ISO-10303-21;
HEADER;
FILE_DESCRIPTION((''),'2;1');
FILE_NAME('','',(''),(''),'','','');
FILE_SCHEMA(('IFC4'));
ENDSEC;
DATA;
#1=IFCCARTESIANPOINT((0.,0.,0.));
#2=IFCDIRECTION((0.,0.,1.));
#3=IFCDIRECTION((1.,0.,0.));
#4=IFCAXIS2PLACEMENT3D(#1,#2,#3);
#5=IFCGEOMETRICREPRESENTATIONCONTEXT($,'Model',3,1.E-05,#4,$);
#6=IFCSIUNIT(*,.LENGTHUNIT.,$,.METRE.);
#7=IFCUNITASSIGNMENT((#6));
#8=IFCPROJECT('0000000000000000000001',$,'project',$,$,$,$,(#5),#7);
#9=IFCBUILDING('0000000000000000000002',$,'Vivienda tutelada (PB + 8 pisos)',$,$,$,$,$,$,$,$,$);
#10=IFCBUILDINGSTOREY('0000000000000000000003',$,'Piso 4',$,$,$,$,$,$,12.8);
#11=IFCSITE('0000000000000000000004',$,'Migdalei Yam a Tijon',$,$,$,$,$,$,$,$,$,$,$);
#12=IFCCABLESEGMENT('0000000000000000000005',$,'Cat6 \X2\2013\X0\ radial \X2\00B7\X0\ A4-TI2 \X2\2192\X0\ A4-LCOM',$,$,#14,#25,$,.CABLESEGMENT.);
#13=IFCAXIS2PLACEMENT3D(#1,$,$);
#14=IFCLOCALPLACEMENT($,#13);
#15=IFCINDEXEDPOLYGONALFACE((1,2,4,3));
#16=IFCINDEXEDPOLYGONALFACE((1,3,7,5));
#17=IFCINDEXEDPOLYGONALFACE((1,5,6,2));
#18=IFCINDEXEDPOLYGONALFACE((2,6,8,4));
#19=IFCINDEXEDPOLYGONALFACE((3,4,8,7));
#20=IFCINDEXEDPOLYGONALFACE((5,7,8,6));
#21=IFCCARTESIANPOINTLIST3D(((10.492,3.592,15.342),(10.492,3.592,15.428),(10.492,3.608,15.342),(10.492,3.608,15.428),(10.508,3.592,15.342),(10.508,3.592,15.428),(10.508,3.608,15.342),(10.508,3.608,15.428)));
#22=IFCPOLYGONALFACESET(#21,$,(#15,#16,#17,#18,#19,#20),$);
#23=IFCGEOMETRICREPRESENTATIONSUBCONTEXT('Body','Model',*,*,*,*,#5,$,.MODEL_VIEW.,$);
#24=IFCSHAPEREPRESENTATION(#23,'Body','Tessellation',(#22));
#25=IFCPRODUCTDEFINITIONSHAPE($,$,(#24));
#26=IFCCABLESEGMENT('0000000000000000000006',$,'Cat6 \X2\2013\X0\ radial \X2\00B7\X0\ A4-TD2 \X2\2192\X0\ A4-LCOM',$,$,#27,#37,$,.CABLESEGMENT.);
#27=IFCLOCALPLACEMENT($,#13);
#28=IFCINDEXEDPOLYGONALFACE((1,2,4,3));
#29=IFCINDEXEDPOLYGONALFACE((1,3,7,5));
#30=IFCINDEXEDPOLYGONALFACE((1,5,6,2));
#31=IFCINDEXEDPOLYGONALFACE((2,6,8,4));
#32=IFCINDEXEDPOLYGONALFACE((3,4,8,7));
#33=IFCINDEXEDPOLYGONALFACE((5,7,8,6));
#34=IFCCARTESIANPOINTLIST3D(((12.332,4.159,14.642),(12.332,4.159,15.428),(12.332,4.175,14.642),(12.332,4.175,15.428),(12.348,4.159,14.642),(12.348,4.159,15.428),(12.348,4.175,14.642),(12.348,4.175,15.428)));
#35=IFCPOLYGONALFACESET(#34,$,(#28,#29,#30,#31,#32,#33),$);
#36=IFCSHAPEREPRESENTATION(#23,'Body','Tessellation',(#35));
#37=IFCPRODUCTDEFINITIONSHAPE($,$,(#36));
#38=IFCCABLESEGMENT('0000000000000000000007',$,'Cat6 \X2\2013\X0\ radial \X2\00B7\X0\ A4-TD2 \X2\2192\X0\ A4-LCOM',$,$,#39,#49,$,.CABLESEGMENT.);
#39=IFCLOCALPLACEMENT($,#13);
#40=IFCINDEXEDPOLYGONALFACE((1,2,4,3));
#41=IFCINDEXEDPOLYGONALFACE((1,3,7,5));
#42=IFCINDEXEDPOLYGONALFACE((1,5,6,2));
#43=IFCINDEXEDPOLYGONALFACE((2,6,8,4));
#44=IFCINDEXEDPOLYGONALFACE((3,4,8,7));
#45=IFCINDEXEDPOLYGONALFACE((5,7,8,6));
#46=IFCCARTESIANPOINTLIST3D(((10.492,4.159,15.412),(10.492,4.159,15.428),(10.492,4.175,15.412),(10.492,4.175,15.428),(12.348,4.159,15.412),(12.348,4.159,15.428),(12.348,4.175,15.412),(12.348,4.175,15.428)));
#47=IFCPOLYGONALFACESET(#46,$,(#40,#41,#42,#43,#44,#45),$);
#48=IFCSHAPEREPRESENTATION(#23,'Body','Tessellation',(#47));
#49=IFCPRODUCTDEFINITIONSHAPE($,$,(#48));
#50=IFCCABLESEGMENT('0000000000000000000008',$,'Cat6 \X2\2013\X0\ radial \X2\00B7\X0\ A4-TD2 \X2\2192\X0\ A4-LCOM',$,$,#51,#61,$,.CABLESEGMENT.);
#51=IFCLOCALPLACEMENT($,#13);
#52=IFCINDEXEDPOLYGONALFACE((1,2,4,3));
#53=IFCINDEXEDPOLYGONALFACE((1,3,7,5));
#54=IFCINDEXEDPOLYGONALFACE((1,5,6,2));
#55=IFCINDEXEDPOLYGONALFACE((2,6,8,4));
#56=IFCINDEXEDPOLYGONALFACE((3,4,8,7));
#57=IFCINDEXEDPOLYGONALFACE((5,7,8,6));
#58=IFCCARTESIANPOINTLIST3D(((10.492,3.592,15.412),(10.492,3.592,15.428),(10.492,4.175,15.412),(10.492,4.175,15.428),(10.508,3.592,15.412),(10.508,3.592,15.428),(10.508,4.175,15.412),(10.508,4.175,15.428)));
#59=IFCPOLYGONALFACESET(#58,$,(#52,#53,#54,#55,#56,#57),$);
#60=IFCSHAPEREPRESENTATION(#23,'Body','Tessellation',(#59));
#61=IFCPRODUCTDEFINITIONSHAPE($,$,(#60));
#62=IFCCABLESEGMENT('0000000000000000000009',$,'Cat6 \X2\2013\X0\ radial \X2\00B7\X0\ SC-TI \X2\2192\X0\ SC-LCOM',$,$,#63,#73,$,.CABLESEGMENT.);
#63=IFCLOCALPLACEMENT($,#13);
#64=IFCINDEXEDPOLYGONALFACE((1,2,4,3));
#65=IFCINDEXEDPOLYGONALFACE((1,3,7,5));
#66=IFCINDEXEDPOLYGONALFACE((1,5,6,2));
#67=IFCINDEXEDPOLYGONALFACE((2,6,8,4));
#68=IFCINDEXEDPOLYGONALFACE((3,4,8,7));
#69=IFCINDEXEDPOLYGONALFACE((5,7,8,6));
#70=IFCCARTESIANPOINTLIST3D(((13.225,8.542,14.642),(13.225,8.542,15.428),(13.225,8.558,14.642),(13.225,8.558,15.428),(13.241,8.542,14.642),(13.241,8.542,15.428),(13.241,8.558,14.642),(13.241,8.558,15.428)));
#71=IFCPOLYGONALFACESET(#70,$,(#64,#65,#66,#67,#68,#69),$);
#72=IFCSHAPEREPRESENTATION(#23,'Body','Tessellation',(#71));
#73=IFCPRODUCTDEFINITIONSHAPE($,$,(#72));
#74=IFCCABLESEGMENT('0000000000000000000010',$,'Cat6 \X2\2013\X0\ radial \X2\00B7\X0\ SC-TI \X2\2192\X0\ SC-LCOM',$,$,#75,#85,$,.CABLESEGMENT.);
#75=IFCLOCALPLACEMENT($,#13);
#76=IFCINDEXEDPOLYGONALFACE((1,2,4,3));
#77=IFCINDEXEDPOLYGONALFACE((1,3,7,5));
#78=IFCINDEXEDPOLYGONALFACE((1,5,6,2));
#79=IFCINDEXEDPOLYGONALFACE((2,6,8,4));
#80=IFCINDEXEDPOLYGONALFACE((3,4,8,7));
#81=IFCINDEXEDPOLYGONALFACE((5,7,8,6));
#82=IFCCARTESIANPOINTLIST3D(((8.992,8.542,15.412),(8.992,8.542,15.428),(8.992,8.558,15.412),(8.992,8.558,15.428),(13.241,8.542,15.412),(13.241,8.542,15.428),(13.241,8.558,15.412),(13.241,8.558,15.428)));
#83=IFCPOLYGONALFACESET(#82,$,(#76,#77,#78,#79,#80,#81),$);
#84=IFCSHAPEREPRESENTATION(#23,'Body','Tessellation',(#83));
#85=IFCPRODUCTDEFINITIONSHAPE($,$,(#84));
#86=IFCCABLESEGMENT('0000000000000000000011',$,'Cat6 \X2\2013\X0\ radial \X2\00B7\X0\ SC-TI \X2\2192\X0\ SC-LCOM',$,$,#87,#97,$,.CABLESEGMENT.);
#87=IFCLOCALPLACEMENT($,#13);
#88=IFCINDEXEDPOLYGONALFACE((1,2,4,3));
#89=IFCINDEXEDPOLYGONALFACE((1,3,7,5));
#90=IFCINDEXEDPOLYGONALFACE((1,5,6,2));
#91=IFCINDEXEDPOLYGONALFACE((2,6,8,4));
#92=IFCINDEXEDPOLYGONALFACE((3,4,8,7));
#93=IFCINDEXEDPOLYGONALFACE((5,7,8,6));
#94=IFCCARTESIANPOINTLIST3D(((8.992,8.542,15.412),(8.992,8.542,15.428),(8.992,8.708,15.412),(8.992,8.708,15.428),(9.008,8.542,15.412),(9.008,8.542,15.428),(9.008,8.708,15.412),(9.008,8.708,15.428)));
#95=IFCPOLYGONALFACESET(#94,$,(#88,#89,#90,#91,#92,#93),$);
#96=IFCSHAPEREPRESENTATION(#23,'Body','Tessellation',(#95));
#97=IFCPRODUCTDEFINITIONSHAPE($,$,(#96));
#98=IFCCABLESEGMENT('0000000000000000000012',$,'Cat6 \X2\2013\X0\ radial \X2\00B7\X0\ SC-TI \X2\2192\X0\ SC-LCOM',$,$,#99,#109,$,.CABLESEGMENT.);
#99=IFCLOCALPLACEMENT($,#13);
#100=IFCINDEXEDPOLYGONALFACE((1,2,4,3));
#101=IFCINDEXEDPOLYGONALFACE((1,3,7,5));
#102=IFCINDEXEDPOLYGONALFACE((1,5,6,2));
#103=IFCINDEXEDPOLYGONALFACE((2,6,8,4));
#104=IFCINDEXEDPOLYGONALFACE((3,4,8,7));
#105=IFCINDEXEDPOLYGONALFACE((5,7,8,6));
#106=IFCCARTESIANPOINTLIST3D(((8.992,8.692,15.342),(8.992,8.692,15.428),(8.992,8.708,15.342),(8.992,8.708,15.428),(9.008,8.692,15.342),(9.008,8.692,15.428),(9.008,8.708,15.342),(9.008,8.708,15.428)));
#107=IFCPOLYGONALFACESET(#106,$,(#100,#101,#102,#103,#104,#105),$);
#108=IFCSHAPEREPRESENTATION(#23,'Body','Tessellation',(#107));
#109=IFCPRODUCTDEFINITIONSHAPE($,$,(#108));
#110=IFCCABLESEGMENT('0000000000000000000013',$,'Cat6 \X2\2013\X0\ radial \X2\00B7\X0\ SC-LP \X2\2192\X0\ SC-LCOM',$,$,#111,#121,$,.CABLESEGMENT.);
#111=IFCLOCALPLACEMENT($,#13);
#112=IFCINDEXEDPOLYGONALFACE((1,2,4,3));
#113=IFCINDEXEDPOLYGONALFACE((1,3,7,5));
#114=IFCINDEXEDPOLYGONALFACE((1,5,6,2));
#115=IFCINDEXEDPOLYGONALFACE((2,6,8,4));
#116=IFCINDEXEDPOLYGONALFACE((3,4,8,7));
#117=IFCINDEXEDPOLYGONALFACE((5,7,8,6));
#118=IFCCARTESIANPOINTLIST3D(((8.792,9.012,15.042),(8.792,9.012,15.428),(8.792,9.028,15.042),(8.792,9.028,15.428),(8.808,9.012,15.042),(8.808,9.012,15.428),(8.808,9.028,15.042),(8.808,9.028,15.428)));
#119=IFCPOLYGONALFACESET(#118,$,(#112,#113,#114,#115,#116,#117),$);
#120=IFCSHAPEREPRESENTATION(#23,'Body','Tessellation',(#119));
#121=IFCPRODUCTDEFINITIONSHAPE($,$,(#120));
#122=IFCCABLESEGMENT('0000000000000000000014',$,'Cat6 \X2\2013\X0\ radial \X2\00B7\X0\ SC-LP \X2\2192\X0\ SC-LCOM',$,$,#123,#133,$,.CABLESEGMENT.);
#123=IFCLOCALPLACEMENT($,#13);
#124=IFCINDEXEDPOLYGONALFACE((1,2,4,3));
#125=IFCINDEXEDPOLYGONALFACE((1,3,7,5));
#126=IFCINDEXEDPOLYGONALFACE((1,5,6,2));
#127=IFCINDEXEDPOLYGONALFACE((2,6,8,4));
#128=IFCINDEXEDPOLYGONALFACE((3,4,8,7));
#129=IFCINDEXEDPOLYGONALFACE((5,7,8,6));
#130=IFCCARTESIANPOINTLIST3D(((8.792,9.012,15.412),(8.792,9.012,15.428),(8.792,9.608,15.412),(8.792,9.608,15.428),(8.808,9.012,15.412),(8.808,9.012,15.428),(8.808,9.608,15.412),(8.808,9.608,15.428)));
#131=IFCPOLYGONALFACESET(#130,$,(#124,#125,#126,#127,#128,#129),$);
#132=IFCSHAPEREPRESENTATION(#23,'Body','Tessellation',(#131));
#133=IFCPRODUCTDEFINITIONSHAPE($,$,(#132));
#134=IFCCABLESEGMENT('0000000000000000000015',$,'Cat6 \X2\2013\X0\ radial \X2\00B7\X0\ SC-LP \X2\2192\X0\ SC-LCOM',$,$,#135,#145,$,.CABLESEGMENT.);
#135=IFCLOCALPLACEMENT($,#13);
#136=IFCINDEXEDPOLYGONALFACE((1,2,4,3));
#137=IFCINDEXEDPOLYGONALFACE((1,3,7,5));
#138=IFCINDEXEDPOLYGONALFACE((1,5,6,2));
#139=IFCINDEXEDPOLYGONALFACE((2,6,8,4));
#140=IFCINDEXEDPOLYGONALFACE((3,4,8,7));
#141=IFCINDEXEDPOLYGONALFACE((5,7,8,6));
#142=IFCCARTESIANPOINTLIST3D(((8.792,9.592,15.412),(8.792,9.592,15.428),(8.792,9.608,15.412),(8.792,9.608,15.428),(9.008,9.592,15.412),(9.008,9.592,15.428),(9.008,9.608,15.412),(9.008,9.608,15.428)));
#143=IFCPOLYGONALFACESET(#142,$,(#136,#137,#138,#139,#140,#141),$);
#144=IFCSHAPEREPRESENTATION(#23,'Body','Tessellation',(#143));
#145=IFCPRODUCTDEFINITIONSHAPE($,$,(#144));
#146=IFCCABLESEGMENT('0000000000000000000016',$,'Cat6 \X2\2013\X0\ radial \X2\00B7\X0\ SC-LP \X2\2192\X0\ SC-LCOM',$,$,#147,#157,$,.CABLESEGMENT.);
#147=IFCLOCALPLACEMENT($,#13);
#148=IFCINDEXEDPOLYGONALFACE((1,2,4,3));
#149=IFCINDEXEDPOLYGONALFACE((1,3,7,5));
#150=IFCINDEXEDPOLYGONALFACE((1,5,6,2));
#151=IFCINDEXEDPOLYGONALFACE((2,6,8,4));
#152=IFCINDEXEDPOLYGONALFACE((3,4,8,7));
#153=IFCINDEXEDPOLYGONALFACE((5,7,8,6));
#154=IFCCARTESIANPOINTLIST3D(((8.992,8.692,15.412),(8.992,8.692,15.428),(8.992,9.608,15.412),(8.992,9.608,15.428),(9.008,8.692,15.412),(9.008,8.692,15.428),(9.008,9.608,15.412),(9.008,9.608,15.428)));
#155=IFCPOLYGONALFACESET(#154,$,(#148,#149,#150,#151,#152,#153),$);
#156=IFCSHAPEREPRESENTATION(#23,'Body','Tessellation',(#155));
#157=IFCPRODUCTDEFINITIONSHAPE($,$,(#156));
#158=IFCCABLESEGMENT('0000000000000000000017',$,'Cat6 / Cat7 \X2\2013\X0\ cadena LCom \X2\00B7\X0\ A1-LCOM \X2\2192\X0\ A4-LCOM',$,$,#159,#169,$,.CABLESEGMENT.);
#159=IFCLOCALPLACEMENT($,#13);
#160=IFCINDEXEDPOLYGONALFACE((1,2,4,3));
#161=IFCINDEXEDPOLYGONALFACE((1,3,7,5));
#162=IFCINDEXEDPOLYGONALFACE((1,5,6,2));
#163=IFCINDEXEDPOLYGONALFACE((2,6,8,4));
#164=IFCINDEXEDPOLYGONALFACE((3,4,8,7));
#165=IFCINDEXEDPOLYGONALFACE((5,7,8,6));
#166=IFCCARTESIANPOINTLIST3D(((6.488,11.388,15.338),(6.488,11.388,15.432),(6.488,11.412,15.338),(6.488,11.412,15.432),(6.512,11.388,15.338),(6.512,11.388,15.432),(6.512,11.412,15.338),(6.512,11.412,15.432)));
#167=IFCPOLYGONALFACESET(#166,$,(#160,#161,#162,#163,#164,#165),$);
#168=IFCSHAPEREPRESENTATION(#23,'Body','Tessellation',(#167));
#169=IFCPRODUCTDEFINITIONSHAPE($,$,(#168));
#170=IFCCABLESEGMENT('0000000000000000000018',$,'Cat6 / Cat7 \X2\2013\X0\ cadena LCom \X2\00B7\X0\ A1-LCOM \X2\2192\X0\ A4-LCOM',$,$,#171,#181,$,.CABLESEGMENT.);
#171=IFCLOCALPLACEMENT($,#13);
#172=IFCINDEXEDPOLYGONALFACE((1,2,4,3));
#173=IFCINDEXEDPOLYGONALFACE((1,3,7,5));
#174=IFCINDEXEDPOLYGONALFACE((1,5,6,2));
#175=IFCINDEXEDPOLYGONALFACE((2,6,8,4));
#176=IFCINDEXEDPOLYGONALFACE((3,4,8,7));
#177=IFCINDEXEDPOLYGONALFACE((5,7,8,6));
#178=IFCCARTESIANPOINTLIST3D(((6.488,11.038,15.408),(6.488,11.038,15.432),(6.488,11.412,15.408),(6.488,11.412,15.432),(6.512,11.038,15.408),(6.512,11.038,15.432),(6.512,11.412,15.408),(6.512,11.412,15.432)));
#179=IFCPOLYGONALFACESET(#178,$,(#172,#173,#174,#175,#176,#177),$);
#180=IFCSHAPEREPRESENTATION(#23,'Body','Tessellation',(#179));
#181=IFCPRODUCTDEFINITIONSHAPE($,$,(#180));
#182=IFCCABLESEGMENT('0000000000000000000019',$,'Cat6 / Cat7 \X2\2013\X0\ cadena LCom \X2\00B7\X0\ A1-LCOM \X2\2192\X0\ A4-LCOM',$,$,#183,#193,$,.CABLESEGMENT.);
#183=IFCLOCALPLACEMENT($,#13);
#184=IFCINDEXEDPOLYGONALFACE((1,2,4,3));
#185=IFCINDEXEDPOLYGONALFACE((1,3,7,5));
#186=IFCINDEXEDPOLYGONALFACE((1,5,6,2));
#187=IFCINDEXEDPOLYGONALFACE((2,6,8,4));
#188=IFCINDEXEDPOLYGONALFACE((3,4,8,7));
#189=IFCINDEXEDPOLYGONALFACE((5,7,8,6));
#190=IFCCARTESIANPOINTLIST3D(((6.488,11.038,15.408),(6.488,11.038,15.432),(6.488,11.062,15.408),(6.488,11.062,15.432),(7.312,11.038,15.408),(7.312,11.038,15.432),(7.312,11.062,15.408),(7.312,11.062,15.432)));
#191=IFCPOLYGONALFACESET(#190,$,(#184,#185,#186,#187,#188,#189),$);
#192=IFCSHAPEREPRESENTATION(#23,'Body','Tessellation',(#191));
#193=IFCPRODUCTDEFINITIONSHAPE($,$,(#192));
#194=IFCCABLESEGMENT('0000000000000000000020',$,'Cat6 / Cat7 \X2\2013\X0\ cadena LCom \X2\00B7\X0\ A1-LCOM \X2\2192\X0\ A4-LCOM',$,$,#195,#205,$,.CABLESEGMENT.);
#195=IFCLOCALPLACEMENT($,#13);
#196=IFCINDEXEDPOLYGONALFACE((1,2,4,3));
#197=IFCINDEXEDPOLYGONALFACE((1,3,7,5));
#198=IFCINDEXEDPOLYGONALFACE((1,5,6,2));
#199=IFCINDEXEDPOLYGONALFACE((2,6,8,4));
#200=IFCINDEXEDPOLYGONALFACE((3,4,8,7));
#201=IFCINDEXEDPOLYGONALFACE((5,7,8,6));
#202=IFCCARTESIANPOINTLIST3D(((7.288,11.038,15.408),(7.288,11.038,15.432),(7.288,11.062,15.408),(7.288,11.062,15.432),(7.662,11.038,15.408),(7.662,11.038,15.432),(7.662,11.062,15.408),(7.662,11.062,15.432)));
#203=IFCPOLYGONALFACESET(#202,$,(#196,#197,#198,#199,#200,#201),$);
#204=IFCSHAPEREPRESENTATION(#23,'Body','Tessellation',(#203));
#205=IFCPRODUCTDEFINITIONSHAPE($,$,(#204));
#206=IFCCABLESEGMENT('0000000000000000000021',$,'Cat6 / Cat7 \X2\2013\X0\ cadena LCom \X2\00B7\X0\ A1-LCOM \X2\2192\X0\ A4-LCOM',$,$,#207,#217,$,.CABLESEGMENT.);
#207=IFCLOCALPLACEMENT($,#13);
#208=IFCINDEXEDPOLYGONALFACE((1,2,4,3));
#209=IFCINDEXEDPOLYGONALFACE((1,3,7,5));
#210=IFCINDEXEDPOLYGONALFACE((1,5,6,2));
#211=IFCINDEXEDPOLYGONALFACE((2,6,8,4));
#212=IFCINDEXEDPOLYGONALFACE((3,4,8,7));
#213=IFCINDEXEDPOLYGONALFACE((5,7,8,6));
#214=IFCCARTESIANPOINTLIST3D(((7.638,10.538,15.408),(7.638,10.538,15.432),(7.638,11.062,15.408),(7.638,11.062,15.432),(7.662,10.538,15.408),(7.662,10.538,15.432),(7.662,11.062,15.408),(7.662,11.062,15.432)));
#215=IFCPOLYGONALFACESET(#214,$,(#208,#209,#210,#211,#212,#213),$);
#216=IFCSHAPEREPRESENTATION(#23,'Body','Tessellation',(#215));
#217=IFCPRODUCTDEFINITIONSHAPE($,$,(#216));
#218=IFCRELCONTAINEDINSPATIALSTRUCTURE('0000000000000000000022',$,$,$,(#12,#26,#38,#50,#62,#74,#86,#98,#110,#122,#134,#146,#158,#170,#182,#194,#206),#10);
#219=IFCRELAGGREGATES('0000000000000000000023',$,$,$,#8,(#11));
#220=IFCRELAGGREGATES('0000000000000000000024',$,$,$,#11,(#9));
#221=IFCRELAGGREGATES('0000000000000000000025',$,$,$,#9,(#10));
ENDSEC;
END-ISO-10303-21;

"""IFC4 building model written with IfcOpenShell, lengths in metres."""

from ifc_helpers import new_model, si_unit, frame, origin_with_axes, context, subcontext, project, spatial, line, indexed_curve, outline, extrude, element, save


model = new_model("IFC4")

# Units and contexts
model_context = context("Model", 3, precision=1e-05, world=origin_with_axes())
body_context = subcontext(model_context, "Body", "Model", "MODEL_VIEW")
ifc_project = project(units=[si_unit("LENGTHUNIT", "METRE")], contexts=[model_context])

# Site, building, storey
site = spatial("IfcSite", under=ifc_project, Name="Migdalei Yam a Tijon")
building = spatial("IfcBuilding", under=site, Name="Vivienda tutelada (PB + 8 pisos)")
storey = spatial("IfcBuildingStorey", under=building, Name="Piso 4", Elevation=12.8)

# Cable segments
element("IfcCableSegment", 1, inside=storey, Name="Cat6 – radial · A4-TI2 → A4-LCOM", PredefinedType="CABLESEGMENT", context=body_context, shape_type="SweptSolid", body=[
    extrude(outline(indexed_curve([(0.0, 0.0), (0.016, 0.0), (0.016, 0.016), (0.0, 0.016)], segments=[line(1, 2, 3, 4, 1)])), frame((10.492, 3.592, 15.342), z_axis=(0.0, 0.0, 1.0), x_axis=(1.0, 0.0, 0.0)), (0.0, 0.0, 1.0), 0.086),
])
element("IfcCableSegment", 2, inside=storey, Name="Cat6 – radial · A4-TD2 → A4-LCOM", PredefinedType="CABLESEGMENT", context=body_context, shape_type="SweptSolid", body=[
    extrude(outline(indexed_curve([(0.0, 0.0), (0.016, 0.0), (0.016, 0.016), (0.0, 0.016)], segments=[line(1, 2, 3, 4, 1)])), frame((12.332, 4.159, 14.642), z_axis=(0.0, 0.0, 1.0), x_axis=(1.0, 0.0, 0.0)), (0.0, 0.0, 1.0), 0.786),
])
element("IfcCableSegment", 3, inside=storey, Name="Cat6 – radial · A4-TD2 → A4-LCOM", PredefinedType="CABLESEGMENT", context=body_context, shape_type="SweptSolid", body=[
    extrude(outline(indexed_curve([(0.0, 0.0), (1.856, 0.0), (1.856, 0.016), (0.0, 0.016)], segments=[line(1, 2, 3, 4, 1)])), frame((10.492, 4.159, 15.412), z_axis=(0.0, 0.0, 1.0), x_axis=(1.0, 0.0, 0.0)), (0.0, 0.0, 1.0), 0.016),
])
element("IfcCableSegment", 4, inside=storey, Name="Cat6 – radial · A4-TD2 → A4-LCOM", PredefinedType="CABLESEGMENT", context=body_context, shape_type="SweptSolid", body=[
    extrude(outline(indexed_curve([(0.0, 0.0), (0.016, 0.0), (0.016, 0.583), (0.0, 0.583)], segments=[line(1, 2, 3, 4, 1)])), frame((10.492, 3.592, 15.412), z_axis=(0.0, 0.0, 1.0), x_axis=(1.0, 0.0, 0.0)), (0.0, 0.0, 1.0), 0.016),
])
element("IfcCableSegment", 5, inside=storey, Name="Cat6 – radial · SC-TI → SC-LCOM", PredefinedType="CABLESEGMENT", context=body_context, shape_type="SweptSolid", body=[
    extrude(outline(indexed_curve([(0.0, 0.0), (0.016, 0.0), (0.016, 0.016), (0.0, 0.016)], segments=[line(1, 2, 3, 4, 1)])), frame((13.225, 8.542, 14.642), z_axis=(0.0, 0.0, 1.0), x_axis=(1.0, 0.0, 0.0)), (0.0, 0.0, 1.0), 0.786),
])
element("IfcCableSegment", 6, inside=storey, Name="Cat6 – radial · SC-TI → SC-LCOM", PredefinedType="CABLESEGMENT", context=body_context, shape_type="SweptSolid", body=[
    extrude(outline(indexed_curve([(0.0, 0.0), (4.249, 0.0), (4.249, 0.016), (0.0, 0.016)], segments=[line(1, 2, 3, 4, 1)])), frame((8.992, 8.542, 15.412), z_axis=(0.0, 0.0, 1.0), x_axis=(1.0, 0.0, 0.0)), (0.0, 0.0, 1.0), 0.016),
])
element("IfcCableSegment", 7, inside=storey, Name="Cat6 – radial · SC-TI → SC-LCOM", PredefinedType="CABLESEGMENT", context=body_context, shape_type="SweptSolid", body=[
    extrude(outline(indexed_curve([(0.0, 0.0), (0.016, 0.0), (0.016, 0.166), (0.0, 0.166)], segments=[line(1, 2, 3, 4, 1)])), frame((8.992, 8.542, 15.412), z_axis=(0.0, 0.0, 1.0), x_axis=(1.0, 0.0, 0.0)), (0.0, 0.0, 1.0), 0.016),
])
element("IfcCableSegment", 8, inside=storey, Name="Cat6 – radial · SC-TI → SC-LCOM", PredefinedType="CABLESEGMENT", context=body_context, shape_type="SweptSolid", body=[
    extrude(outline(indexed_curve([(0.0, 0.0), (0.016, 0.0), (0.016, 0.016), (0.0, 0.016)], segments=[line(1, 2, 3, 4, 1)])), frame((8.992, 8.692, 15.342), z_axis=(0.0, 0.0, 1.0), x_axis=(1.0, 0.0, 0.0)), (0.0, 0.0, 1.0), 0.086),
])
element("IfcCableSegment", 9, inside=storey, Name="Cat6 – radial · SC-LP → SC-LCOM", PredefinedType="CABLESEGMENT", context=body_context, shape_type="SweptSolid", body=[
    extrude(outline(indexed_curve([(0.0, 0.0), (0.016, 0.0), (0.016, 0.016), (0.0, 0.016)], segments=[line(1, 2, 3, 4, 1)])), frame((8.792, 9.012, 15.042), z_axis=(0.0, 0.0, 1.0), x_axis=(1.0, 0.0, 0.0)), (0.0, 0.0, 1.0), 0.386),
])
element("IfcCableSegment", 10, inside=storey, Name="Cat6 – radial · SC-LP → SC-LCOM", PredefinedType="CABLESEGMENT", context=body_context, shape_type="SweptSolid", body=[
    extrude(outline(indexed_curve([(0.0, 0.0), (0.016, 0.0), (0.016, 0.596), (0.0, 0.596)], segments=[line(1, 2, 3, 4, 1)])), frame((8.792, 9.012, 15.412), z_axis=(0.0, 0.0, 1.0), x_axis=(1.0, 0.0, 0.0)), (0.0, 0.0, 1.0), 0.016),
])
element("IfcCableSegment", 11, inside=storey, Name="Cat6 – radial · SC-LP → SC-LCOM", PredefinedType="CABLESEGMENT", context=body_context, shape_type="SweptSolid", body=[
    extrude(outline(indexed_curve([(0.0, 0.0), (0.216, 0.0), (0.216, 0.016), (0.0, 0.016)], segments=[line(1, 2, 3, 4, 1)])), frame((8.792, 9.592, 15.412), z_axis=(0.0, 0.0, 1.0), x_axis=(1.0, 0.0, 0.0)), (0.0, 0.0, 1.0), 0.016),
])
element("IfcCableSegment", 12, inside=storey, Name="Cat6 – radial · SC-LP → SC-LCOM", PredefinedType="CABLESEGMENT", context=body_context, shape_type="SweptSolid", body=[
    extrude(outline(indexed_curve([(0.0, 0.0), (0.016, 0.0), (0.016, 0.916), (0.0, 0.916)], segments=[line(1, 2, 3, 4, 1)])), frame((8.992, 8.692, 15.412), z_axis=(0.0, 0.0, 1.0), x_axis=(1.0, 0.0, 0.0)), (0.0, 0.0, 1.0), 0.016),
])
element("IfcCableSegment", 13, inside=storey, Name="Cat6 / Cat7 – cadena LCom · A1-LCOM → A4-LCOM", PredefinedType="CABLESEGMENT", context=body_context, shape_type="SweptSolid", body=[
    extrude(outline(indexed_curve([(0.0, 0.0), (0.024, 0.0), (0.024, 0.024), (0.0, 0.024)], segments=[line(1, 2, 3, 4, 1)])), frame((6.488, 11.388, 15.338), z_axis=(0.0, 0.0, 1.0), x_axis=(1.0, 0.0, 0.0)), (0.0, 0.0, 1.0), 0.094),
])
element("IfcCableSegment", 14, inside=storey, Name="Cat6 / Cat7 – cadena LCom · A1-LCOM → A4-LCOM", PredefinedType="CABLESEGMENT", context=body_context, shape_type="SweptSolid", body=[
    extrude(outline(indexed_curve([(0.0, 0.0), (0.024, 0.0), (0.024, 0.374), (0.0, 0.374)], segments=[line(1, 2, 3, 4, 1)])), frame((6.488, 11.038, 15.408), z_axis=(0.0, 0.0, 1.0), x_axis=(1.0, 0.0, 0.0)), (0.0, 0.0, 1.0), 0.024),
])
element("IfcCableSegment", 15, inside=storey, Name="Cat6 / Cat7 – cadena LCom · A1-LCOM → A4-LCOM", PredefinedType="CABLESEGMENT", context=body_context, shape_type="SweptSolid", body=[
    extrude(outline(indexed_curve([(0.0, 0.0), (0.824, 0.0), (0.824, 0.024), (0.0, 0.024)], segments=[line(1, 2, 3, 4, 1)])), frame((6.488, 11.038, 15.408), z_axis=(0.0, 0.0, 1.0), x_axis=(1.0, 0.0, 0.0)), (0.0, 0.0, 1.0), 0.024),
])
element("IfcCableSegment", 16, inside=storey, Name="Cat6 / Cat7 – cadena LCom · A1-LCOM → A4-LCOM", PredefinedType="CABLESEGMENT", context=body_context, shape_type="SweptSolid", body=[
    extrude(outline(indexed_curve([(0.0, 0.0), (0.374, 0.0), (0.374, 0.024), (0.0, 0.024)], segments=[line(1, 2, 3, 4, 1)])), frame((7.288, 11.038, 15.408), z_axis=(0.0, 0.0, 1.0), x_axis=(1.0, 0.0, 0.0)), (0.0, 0.0, 1.0), 0.024),
])
element("IfcCableSegment", 17, inside=storey, Name="Cat6 / Cat7 – cadena LCom · A1-LCOM → A4-LCOM", PredefinedType="CABLESEGMENT", context=body_context, shape_type="SweptSolid", body=[
    extrude(outline(indexed_curve([(0.0, 0.0), (0.024, 0.0), (0.024, 0.524), (0.0, 0.524)], segments=[line(1, 2, 3, 4, 1)])), frame((7.638, 10.538, 15.408), z_axis=(0.0, 0.0, 1.0), x_axis=(1.0, 0.0, 0.0)), (0.0, 0.0, 1.0), 0.024),
])

save(model, "model.ifc")
